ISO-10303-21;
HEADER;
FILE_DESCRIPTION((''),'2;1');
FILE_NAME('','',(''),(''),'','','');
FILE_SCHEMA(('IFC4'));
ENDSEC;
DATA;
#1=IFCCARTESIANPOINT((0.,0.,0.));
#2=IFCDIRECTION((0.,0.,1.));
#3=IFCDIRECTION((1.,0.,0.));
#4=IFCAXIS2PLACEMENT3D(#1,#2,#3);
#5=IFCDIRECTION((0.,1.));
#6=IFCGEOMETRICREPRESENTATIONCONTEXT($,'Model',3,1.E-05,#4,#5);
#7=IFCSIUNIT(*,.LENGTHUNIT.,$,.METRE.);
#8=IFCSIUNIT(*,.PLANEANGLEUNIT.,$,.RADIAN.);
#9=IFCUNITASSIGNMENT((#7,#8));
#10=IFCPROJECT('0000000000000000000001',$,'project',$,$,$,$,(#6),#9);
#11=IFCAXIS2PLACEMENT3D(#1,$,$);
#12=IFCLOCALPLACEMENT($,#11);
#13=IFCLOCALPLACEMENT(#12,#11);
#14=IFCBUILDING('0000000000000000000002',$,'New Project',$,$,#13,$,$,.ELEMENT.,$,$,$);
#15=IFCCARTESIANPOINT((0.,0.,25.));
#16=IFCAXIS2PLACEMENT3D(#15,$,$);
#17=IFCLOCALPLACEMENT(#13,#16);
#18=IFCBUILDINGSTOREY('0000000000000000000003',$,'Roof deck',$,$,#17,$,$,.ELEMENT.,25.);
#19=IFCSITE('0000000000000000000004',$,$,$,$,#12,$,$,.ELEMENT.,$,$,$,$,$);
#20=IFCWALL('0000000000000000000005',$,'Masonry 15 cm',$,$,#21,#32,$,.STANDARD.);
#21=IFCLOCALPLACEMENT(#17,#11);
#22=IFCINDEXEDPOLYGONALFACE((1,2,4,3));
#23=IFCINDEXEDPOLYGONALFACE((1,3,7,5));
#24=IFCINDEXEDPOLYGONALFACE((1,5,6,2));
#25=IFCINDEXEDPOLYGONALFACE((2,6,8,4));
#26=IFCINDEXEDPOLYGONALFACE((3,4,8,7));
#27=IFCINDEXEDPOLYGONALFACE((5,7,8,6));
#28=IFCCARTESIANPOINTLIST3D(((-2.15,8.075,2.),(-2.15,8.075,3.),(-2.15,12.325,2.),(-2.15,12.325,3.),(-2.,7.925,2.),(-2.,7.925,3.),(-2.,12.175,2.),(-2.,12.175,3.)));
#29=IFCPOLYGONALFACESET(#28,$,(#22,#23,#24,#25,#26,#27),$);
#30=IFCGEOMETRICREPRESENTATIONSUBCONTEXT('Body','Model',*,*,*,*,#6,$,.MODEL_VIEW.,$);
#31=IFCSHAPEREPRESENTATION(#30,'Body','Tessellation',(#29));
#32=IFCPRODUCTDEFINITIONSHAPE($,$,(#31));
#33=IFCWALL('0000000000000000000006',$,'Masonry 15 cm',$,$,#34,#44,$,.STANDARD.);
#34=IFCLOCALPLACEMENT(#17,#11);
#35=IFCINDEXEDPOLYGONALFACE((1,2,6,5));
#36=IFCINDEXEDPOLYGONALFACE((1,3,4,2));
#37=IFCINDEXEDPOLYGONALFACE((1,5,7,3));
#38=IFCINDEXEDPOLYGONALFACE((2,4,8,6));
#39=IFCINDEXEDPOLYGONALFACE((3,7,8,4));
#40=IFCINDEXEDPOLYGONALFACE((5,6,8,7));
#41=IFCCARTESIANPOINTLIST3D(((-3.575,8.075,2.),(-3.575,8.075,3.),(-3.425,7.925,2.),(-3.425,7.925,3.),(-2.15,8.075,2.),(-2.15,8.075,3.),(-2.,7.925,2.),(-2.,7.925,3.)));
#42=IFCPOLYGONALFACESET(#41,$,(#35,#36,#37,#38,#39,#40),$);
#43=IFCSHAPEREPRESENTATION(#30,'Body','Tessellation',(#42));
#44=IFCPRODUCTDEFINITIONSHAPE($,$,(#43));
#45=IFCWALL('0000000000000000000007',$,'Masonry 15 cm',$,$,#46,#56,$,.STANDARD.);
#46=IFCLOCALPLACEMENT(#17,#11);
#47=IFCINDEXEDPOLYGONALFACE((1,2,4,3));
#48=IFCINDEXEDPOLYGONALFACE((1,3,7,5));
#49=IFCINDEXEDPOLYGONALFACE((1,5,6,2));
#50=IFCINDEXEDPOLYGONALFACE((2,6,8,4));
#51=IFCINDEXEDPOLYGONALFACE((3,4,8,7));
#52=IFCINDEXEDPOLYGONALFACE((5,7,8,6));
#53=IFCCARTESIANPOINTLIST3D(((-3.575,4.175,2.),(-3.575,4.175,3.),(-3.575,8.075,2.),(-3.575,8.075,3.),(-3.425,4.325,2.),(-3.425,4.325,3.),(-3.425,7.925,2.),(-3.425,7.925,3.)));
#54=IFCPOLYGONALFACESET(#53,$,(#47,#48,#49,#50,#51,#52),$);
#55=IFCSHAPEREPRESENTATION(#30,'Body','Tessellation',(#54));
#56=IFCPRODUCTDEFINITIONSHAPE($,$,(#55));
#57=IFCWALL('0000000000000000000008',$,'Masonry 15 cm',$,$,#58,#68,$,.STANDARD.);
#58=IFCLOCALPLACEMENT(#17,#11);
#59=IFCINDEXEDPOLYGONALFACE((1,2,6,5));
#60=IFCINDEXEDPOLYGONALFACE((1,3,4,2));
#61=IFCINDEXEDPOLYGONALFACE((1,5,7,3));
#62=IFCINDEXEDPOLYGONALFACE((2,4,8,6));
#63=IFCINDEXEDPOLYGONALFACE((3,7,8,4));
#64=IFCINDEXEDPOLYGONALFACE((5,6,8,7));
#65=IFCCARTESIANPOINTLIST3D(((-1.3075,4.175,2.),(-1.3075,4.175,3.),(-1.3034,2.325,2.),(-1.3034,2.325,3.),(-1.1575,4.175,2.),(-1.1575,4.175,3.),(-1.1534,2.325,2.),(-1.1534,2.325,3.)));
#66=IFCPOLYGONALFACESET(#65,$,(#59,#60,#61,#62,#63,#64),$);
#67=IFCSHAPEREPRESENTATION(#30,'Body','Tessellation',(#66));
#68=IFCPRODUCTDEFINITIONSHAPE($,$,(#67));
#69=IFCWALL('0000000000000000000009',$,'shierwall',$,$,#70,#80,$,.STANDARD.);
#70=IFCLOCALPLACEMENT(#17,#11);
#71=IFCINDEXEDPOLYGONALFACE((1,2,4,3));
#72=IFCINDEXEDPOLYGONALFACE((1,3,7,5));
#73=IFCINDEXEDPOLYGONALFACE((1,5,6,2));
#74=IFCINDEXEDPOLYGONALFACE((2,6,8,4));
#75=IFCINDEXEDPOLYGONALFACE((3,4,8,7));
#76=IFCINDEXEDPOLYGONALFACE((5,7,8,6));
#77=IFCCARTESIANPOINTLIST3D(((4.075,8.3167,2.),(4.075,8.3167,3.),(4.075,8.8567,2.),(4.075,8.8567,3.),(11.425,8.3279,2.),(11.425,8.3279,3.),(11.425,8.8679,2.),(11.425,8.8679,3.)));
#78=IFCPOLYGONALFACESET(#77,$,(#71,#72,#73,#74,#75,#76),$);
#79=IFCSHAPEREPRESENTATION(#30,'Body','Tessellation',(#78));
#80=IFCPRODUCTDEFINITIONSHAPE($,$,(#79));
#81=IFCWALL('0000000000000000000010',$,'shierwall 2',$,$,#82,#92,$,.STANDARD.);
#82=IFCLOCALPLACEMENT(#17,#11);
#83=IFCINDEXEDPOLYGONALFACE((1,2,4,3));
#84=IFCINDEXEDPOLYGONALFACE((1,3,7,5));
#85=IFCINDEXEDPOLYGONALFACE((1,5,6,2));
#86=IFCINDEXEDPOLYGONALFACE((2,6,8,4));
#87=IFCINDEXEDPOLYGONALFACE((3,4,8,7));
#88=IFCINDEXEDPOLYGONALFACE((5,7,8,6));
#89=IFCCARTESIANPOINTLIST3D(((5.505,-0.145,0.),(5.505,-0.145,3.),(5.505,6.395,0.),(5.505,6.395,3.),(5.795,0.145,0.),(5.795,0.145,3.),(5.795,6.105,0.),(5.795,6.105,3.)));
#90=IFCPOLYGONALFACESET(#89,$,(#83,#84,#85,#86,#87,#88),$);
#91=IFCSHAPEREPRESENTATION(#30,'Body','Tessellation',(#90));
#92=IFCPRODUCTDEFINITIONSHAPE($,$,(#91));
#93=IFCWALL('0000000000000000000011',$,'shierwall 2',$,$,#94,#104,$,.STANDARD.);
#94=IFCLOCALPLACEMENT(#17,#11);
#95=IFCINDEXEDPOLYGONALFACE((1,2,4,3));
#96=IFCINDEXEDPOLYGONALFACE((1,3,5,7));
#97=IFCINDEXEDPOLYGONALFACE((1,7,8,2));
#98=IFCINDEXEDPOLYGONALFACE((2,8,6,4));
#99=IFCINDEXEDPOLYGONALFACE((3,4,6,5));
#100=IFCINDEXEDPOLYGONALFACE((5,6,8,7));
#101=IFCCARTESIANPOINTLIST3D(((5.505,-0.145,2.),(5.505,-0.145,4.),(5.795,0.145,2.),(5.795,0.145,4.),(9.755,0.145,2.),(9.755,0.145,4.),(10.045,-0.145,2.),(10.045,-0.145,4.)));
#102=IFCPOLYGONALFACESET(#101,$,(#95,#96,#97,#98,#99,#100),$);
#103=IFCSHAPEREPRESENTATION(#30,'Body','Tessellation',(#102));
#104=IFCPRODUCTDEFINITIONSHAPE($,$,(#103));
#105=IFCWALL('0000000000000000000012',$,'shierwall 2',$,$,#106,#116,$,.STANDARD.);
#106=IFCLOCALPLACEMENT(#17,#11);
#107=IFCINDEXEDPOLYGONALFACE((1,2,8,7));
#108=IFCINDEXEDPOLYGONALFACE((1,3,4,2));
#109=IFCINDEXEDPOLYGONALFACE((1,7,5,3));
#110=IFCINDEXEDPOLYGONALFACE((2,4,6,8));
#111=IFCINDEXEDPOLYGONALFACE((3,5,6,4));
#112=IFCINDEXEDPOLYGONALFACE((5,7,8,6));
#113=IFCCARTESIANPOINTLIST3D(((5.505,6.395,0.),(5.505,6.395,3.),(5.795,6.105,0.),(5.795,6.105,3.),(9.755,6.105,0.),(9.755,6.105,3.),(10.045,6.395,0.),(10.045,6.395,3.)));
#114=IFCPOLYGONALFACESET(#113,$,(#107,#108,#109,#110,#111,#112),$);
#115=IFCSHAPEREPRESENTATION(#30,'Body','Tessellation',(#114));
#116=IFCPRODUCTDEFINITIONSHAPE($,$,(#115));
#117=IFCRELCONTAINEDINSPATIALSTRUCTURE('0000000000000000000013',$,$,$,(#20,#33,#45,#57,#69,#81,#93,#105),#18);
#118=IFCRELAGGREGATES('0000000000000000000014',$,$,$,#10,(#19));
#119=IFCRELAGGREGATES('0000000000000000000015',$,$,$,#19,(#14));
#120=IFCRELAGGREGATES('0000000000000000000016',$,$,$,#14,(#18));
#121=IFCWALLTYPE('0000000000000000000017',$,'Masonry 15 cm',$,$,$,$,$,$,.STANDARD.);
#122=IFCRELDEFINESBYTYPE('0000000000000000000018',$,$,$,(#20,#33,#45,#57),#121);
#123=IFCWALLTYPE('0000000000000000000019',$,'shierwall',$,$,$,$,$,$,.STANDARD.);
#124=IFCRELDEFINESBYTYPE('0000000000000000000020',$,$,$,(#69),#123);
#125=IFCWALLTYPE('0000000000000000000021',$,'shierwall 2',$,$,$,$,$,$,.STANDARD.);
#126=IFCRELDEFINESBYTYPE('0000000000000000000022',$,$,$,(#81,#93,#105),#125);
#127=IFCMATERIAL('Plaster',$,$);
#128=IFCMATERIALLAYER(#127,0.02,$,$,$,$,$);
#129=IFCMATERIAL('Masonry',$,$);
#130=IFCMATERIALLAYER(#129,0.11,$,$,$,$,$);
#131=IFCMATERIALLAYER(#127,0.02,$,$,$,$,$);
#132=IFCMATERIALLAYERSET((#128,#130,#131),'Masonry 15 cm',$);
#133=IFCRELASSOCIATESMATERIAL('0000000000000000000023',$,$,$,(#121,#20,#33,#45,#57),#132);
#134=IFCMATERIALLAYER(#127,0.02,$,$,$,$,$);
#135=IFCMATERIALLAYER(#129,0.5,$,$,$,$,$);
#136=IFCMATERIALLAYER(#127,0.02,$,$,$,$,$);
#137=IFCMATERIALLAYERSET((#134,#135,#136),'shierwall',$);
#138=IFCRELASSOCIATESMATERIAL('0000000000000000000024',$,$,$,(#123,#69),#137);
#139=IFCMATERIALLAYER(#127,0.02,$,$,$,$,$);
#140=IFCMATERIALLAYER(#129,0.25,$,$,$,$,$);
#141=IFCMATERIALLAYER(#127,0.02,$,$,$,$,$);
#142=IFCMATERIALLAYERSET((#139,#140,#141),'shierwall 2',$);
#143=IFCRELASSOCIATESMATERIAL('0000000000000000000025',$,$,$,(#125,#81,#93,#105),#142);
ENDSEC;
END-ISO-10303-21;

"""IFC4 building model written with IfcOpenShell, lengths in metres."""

from ifc_helpers import new_model, si_unit, direction, frame, origin, origin_with_axes, place, context, subcontext, project, spatial, polyline, outline, extrude, material, layer, layer_set, layer_usage, type_object, element, save


model = new_model("IFC4")

# Units and contexts
model_context = context("Model", 3, precision=1e-05, world=origin_with_axes(), true_north=direction((0.0, 1.0)))
body_context = subcontext(model_context, "Body", "Model", "MODEL_VIEW")
ifc_project = project(units=[si_unit("LENGTHUNIT", "METRE"), si_unit("PLANEANGLEUNIT", "RADIAN")], contexts=[model_context])

# Site, building, storey
site_placement = place(None, origin())
site = spatial("IfcSite", under=ifc_project, at=site_placement, CompositionType="ELEMENT")
building_placement = place(site_placement, origin())
building = spatial("IfcBuilding", under=site, at=building_placement, Name="New Project", CompositionType="ELEMENT")
storey_placement = place(building_placement, frame((0.0, 0.0, 25.0)))
storey = spatial("IfcBuildingStorey", under=building, at=storey_placement, Name="Roof deck", CompositionType="ELEMENT", Elevation=25.0)

# Walls
ifc_material_1 = material(Name="Plaster")
ifc_layer_1 = layer(ifc_material_1, 0.02)
ifc_material_2 = material(Name="Masonry")
ifc_layer_2 = layer(ifc_material_2, 0.11)
ifc_layer_3 = layer(ifc_material_1, 0.02)
ifc_layer_set_1 = layer_set([ifc_layer_1, ifc_layer_2, ifc_layer_3], Name="Masonry 15 cm")
ifc_layer_usage_1 = layer_usage(ifc_layer_set_1, "AXIS2", "NEGATIVE", 0.075)
wall_type_1 = type_object("IfcWallType", Name="Masonry 15 cm", PredefinedType="STANDARD", material=ifc_layer_set_1)
wall_1_placement = place(storey_placement, frame((-2.075, 8.0, 2.0), z_axis=(0.0, 0.0, 1.0), x_axis=(0.0, 1.0, 0.0)))
element("IfcWall", 1, at=wall_1_placement, inside=storey, type_object=wall_type_1, material=ifc_layer_usage_1, Name="Masonry 15 cm", PredefinedType="STANDARD", context=body_context, shape_type="SweptSolid", body=[
    extrude(outline(polyline([(-0.075, -0.075), (4.175, -0.075), (4.325, 0.075), (0.075, 0.075), (-0.075, -0.075)])), origin(), (0.0, 0.0, 1.0), 1.0),
])
wall_2_placement = place(storey_placement, frame((-3.5, 8.0, 2.0), z_axis=(0.0, 0.0, 1.0), x_axis=(1.0, 0.0, 0.0)))
element("IfcWall", 2, at=wall_2_placement, inside=storey, type_object=wall_type_1, material=ifc_layer_usage_1, Name="Masonry 15 cm", PredefinedType="STANDARD", context=body_context, shape_type="SweptSolid", body=[
    extrude(outline(polyline([(0.075, -0.075), (1.5, -0.075), (1.35, 0.075), (-0.075, 0.075), (0.075, -0.075)])), origin(), (0.0, 0.0, 1.0), 1.0),
])
wall_3_placement = place(storey_placement, frame((-3.5, 4.25, 2.0), z_axis=(0.0, 0.0, 1.0), x_axis=(0.0, 1.0, 0.0)))
element("IfcWall", 3, at=wall_3_placement, inside=storey, type_object=wall_type_1, material=ifc_layer_usage_1, Name="Masonry 15 cm", PredefinedType="STANDARD", context=body_context, shape_type="SweptSolid", body=[
    extrude(outline(polyline([(0.075, -0.075), (3.675, -0.075), (3.825, 0.075), (-0.075, 0.075), (0.075, -0.075)])), origin(), (0.0, 0.0, 1.0), 1.0),
])
wall_4_placement = place(storey_placement, frame((-1.2325, 4.175, 2.0), z_axis=(0.0, 0.0, 1.0), x_axis=(0.002207, -0.999998, 0.0)))
element("IfcWall", 4, at=wall_4_placement, inside=storey, type_object=wall_type_1, material=ifc_layer_usage_1, Name="Masonry 15 cm", PredefinedType="STANDARD", context=body_context, shape_type="SweptSolid", body=[
    extrude(outline(polyline([(-0.0002, -0.075), (1.8498, -0.075), (1.8502, 0.075), (0.0002, 0.075), (-0.0002, -0.075)])), origin(), (0.0, 0.0, 1.0), 1.0),
])
ifc_layer_4 = layer(ifc_material_1, 0.02)
ifc_layer_5 = layer(ifc_material_2, 0.5)
ifc_layer_6 = layer(ifc_material_1, 0.02)
ifc_layer_set_2 = layer_set([ifc_layer_4, ifc_layer_5, ifc_layer_6], Name="shierwall")
ifc_layer_usage_2 = layer_usage(ifc_layer_set_2, "AXIS2", "NEGATIVE", 0.27)
wall_type_2 = type_object("IfcWallType", Name="shierwall", PredefinedType="STANDARD", material=ifc_layer_set_2)
wall_5_placement = place(storey_placement, frame((4.075, 8.5867, 2.0), z_axis=(0.0, 0.0, 1.0), x_axis=(0.999999, 0.001534, 0.0)))
element("IfcWall", 5, at=wall_5_placement, inside=storey, type_object=wall_type_2, material=ifc_layer_usage_2, Name="shierwall", PredefinedType="STANDARD", context=body_context, shape_type="SweptSolid", body=[
    extrude(outline(polyline([(-0.0004, -0.27), (7.3496, -0.27), (7.3504, 0.27), (0.0004, 0.27), (-0.0004, -0.27)])), origin(), (0.0, 0.0, 1.0), 1.0),
])
ifc_layer_7 = layer(ifc_material_1, 0.02)
ifc_layer_8 = layer(ifc_material_2, 0.25)
ifc_layer_9 = layer(ifc_material_1, 0.02)
ifc_layer_set_3 = layer_set([ifc_layer_7, ifc_layer_8, ifc_layer_9], Name="shierwall 2")
ifc_layer_usage_3 = layer_usage(ifc_layer_set_3, "AXIS2", "NEGATIVE", 0.145)
wall_type_3 = type_object("IfcWallType", Name="shierwall 2", PredefinedType="STANDARD", material=ifc_layer_set_3)
wall_6_placement = place(storey_placement, frame((5.65, 6.25, 0.0), z_axis=(0.0, 0.0, 1.0), x_axis=(0.0, -1.0, 0.0)))
element("IfcWall", 6, at=wall_6_placement, inside=storey, type_object=wall_type_3, material=ifc_layer_usage_3, Name="shierwall 2", PredefinedType="STANDARD", context=body_context, shape_type="SweptSolid", body=[
    extrude(outline(polyline([(-0.145, -0.145), (6.395, -0.145), (6.105, 0.145), (0.145, 0.145), (-0.145, -0.145)])), origin(), (0.0, 0.0, 1.0), 3.0),
])
wall_7_placement = place(storey_placement, frame((5.65, 0.0, 2.0)))
element("IfcWall", 7, at=wall_7_placement, inside=storey, type_object=wall_type_3, material=ifc_layer_usage_3, Name="shierwall 2", PredefinedType="STANDARD", context=body_context, shape_type="SweptSolid", body=[
    extrude(outline(polyline([(-0.145, -0.145), (4.395, -0.145), (4.105, 0.145), (0.145, 0.145), (-0.145, -0.145)])), origin(), (0.0, 0.0, 1.0), 2.0),
])
wall_8_placement = place(storey_placement, frame((5.65, 6.25, 0.0)))
element("IfcWall", 8, at=wall_8_placement, inside=storey, type_object=wall_type_3, material=ifc_layer_usage_3, Name="shierwall 2", PredefinedType="STANDARD", context=body_context, shape_type="SweptSolid", body=[
    extrude(outline(polyline([(0.145, -0.145), (4.105, -0.145), (4.395, 0.145), (-0.145, 0.145), (0.145, -0.145)])), origin(), (0.0, 0.0, 1.0), 3.0),
])

save(model, "model.ifc")
